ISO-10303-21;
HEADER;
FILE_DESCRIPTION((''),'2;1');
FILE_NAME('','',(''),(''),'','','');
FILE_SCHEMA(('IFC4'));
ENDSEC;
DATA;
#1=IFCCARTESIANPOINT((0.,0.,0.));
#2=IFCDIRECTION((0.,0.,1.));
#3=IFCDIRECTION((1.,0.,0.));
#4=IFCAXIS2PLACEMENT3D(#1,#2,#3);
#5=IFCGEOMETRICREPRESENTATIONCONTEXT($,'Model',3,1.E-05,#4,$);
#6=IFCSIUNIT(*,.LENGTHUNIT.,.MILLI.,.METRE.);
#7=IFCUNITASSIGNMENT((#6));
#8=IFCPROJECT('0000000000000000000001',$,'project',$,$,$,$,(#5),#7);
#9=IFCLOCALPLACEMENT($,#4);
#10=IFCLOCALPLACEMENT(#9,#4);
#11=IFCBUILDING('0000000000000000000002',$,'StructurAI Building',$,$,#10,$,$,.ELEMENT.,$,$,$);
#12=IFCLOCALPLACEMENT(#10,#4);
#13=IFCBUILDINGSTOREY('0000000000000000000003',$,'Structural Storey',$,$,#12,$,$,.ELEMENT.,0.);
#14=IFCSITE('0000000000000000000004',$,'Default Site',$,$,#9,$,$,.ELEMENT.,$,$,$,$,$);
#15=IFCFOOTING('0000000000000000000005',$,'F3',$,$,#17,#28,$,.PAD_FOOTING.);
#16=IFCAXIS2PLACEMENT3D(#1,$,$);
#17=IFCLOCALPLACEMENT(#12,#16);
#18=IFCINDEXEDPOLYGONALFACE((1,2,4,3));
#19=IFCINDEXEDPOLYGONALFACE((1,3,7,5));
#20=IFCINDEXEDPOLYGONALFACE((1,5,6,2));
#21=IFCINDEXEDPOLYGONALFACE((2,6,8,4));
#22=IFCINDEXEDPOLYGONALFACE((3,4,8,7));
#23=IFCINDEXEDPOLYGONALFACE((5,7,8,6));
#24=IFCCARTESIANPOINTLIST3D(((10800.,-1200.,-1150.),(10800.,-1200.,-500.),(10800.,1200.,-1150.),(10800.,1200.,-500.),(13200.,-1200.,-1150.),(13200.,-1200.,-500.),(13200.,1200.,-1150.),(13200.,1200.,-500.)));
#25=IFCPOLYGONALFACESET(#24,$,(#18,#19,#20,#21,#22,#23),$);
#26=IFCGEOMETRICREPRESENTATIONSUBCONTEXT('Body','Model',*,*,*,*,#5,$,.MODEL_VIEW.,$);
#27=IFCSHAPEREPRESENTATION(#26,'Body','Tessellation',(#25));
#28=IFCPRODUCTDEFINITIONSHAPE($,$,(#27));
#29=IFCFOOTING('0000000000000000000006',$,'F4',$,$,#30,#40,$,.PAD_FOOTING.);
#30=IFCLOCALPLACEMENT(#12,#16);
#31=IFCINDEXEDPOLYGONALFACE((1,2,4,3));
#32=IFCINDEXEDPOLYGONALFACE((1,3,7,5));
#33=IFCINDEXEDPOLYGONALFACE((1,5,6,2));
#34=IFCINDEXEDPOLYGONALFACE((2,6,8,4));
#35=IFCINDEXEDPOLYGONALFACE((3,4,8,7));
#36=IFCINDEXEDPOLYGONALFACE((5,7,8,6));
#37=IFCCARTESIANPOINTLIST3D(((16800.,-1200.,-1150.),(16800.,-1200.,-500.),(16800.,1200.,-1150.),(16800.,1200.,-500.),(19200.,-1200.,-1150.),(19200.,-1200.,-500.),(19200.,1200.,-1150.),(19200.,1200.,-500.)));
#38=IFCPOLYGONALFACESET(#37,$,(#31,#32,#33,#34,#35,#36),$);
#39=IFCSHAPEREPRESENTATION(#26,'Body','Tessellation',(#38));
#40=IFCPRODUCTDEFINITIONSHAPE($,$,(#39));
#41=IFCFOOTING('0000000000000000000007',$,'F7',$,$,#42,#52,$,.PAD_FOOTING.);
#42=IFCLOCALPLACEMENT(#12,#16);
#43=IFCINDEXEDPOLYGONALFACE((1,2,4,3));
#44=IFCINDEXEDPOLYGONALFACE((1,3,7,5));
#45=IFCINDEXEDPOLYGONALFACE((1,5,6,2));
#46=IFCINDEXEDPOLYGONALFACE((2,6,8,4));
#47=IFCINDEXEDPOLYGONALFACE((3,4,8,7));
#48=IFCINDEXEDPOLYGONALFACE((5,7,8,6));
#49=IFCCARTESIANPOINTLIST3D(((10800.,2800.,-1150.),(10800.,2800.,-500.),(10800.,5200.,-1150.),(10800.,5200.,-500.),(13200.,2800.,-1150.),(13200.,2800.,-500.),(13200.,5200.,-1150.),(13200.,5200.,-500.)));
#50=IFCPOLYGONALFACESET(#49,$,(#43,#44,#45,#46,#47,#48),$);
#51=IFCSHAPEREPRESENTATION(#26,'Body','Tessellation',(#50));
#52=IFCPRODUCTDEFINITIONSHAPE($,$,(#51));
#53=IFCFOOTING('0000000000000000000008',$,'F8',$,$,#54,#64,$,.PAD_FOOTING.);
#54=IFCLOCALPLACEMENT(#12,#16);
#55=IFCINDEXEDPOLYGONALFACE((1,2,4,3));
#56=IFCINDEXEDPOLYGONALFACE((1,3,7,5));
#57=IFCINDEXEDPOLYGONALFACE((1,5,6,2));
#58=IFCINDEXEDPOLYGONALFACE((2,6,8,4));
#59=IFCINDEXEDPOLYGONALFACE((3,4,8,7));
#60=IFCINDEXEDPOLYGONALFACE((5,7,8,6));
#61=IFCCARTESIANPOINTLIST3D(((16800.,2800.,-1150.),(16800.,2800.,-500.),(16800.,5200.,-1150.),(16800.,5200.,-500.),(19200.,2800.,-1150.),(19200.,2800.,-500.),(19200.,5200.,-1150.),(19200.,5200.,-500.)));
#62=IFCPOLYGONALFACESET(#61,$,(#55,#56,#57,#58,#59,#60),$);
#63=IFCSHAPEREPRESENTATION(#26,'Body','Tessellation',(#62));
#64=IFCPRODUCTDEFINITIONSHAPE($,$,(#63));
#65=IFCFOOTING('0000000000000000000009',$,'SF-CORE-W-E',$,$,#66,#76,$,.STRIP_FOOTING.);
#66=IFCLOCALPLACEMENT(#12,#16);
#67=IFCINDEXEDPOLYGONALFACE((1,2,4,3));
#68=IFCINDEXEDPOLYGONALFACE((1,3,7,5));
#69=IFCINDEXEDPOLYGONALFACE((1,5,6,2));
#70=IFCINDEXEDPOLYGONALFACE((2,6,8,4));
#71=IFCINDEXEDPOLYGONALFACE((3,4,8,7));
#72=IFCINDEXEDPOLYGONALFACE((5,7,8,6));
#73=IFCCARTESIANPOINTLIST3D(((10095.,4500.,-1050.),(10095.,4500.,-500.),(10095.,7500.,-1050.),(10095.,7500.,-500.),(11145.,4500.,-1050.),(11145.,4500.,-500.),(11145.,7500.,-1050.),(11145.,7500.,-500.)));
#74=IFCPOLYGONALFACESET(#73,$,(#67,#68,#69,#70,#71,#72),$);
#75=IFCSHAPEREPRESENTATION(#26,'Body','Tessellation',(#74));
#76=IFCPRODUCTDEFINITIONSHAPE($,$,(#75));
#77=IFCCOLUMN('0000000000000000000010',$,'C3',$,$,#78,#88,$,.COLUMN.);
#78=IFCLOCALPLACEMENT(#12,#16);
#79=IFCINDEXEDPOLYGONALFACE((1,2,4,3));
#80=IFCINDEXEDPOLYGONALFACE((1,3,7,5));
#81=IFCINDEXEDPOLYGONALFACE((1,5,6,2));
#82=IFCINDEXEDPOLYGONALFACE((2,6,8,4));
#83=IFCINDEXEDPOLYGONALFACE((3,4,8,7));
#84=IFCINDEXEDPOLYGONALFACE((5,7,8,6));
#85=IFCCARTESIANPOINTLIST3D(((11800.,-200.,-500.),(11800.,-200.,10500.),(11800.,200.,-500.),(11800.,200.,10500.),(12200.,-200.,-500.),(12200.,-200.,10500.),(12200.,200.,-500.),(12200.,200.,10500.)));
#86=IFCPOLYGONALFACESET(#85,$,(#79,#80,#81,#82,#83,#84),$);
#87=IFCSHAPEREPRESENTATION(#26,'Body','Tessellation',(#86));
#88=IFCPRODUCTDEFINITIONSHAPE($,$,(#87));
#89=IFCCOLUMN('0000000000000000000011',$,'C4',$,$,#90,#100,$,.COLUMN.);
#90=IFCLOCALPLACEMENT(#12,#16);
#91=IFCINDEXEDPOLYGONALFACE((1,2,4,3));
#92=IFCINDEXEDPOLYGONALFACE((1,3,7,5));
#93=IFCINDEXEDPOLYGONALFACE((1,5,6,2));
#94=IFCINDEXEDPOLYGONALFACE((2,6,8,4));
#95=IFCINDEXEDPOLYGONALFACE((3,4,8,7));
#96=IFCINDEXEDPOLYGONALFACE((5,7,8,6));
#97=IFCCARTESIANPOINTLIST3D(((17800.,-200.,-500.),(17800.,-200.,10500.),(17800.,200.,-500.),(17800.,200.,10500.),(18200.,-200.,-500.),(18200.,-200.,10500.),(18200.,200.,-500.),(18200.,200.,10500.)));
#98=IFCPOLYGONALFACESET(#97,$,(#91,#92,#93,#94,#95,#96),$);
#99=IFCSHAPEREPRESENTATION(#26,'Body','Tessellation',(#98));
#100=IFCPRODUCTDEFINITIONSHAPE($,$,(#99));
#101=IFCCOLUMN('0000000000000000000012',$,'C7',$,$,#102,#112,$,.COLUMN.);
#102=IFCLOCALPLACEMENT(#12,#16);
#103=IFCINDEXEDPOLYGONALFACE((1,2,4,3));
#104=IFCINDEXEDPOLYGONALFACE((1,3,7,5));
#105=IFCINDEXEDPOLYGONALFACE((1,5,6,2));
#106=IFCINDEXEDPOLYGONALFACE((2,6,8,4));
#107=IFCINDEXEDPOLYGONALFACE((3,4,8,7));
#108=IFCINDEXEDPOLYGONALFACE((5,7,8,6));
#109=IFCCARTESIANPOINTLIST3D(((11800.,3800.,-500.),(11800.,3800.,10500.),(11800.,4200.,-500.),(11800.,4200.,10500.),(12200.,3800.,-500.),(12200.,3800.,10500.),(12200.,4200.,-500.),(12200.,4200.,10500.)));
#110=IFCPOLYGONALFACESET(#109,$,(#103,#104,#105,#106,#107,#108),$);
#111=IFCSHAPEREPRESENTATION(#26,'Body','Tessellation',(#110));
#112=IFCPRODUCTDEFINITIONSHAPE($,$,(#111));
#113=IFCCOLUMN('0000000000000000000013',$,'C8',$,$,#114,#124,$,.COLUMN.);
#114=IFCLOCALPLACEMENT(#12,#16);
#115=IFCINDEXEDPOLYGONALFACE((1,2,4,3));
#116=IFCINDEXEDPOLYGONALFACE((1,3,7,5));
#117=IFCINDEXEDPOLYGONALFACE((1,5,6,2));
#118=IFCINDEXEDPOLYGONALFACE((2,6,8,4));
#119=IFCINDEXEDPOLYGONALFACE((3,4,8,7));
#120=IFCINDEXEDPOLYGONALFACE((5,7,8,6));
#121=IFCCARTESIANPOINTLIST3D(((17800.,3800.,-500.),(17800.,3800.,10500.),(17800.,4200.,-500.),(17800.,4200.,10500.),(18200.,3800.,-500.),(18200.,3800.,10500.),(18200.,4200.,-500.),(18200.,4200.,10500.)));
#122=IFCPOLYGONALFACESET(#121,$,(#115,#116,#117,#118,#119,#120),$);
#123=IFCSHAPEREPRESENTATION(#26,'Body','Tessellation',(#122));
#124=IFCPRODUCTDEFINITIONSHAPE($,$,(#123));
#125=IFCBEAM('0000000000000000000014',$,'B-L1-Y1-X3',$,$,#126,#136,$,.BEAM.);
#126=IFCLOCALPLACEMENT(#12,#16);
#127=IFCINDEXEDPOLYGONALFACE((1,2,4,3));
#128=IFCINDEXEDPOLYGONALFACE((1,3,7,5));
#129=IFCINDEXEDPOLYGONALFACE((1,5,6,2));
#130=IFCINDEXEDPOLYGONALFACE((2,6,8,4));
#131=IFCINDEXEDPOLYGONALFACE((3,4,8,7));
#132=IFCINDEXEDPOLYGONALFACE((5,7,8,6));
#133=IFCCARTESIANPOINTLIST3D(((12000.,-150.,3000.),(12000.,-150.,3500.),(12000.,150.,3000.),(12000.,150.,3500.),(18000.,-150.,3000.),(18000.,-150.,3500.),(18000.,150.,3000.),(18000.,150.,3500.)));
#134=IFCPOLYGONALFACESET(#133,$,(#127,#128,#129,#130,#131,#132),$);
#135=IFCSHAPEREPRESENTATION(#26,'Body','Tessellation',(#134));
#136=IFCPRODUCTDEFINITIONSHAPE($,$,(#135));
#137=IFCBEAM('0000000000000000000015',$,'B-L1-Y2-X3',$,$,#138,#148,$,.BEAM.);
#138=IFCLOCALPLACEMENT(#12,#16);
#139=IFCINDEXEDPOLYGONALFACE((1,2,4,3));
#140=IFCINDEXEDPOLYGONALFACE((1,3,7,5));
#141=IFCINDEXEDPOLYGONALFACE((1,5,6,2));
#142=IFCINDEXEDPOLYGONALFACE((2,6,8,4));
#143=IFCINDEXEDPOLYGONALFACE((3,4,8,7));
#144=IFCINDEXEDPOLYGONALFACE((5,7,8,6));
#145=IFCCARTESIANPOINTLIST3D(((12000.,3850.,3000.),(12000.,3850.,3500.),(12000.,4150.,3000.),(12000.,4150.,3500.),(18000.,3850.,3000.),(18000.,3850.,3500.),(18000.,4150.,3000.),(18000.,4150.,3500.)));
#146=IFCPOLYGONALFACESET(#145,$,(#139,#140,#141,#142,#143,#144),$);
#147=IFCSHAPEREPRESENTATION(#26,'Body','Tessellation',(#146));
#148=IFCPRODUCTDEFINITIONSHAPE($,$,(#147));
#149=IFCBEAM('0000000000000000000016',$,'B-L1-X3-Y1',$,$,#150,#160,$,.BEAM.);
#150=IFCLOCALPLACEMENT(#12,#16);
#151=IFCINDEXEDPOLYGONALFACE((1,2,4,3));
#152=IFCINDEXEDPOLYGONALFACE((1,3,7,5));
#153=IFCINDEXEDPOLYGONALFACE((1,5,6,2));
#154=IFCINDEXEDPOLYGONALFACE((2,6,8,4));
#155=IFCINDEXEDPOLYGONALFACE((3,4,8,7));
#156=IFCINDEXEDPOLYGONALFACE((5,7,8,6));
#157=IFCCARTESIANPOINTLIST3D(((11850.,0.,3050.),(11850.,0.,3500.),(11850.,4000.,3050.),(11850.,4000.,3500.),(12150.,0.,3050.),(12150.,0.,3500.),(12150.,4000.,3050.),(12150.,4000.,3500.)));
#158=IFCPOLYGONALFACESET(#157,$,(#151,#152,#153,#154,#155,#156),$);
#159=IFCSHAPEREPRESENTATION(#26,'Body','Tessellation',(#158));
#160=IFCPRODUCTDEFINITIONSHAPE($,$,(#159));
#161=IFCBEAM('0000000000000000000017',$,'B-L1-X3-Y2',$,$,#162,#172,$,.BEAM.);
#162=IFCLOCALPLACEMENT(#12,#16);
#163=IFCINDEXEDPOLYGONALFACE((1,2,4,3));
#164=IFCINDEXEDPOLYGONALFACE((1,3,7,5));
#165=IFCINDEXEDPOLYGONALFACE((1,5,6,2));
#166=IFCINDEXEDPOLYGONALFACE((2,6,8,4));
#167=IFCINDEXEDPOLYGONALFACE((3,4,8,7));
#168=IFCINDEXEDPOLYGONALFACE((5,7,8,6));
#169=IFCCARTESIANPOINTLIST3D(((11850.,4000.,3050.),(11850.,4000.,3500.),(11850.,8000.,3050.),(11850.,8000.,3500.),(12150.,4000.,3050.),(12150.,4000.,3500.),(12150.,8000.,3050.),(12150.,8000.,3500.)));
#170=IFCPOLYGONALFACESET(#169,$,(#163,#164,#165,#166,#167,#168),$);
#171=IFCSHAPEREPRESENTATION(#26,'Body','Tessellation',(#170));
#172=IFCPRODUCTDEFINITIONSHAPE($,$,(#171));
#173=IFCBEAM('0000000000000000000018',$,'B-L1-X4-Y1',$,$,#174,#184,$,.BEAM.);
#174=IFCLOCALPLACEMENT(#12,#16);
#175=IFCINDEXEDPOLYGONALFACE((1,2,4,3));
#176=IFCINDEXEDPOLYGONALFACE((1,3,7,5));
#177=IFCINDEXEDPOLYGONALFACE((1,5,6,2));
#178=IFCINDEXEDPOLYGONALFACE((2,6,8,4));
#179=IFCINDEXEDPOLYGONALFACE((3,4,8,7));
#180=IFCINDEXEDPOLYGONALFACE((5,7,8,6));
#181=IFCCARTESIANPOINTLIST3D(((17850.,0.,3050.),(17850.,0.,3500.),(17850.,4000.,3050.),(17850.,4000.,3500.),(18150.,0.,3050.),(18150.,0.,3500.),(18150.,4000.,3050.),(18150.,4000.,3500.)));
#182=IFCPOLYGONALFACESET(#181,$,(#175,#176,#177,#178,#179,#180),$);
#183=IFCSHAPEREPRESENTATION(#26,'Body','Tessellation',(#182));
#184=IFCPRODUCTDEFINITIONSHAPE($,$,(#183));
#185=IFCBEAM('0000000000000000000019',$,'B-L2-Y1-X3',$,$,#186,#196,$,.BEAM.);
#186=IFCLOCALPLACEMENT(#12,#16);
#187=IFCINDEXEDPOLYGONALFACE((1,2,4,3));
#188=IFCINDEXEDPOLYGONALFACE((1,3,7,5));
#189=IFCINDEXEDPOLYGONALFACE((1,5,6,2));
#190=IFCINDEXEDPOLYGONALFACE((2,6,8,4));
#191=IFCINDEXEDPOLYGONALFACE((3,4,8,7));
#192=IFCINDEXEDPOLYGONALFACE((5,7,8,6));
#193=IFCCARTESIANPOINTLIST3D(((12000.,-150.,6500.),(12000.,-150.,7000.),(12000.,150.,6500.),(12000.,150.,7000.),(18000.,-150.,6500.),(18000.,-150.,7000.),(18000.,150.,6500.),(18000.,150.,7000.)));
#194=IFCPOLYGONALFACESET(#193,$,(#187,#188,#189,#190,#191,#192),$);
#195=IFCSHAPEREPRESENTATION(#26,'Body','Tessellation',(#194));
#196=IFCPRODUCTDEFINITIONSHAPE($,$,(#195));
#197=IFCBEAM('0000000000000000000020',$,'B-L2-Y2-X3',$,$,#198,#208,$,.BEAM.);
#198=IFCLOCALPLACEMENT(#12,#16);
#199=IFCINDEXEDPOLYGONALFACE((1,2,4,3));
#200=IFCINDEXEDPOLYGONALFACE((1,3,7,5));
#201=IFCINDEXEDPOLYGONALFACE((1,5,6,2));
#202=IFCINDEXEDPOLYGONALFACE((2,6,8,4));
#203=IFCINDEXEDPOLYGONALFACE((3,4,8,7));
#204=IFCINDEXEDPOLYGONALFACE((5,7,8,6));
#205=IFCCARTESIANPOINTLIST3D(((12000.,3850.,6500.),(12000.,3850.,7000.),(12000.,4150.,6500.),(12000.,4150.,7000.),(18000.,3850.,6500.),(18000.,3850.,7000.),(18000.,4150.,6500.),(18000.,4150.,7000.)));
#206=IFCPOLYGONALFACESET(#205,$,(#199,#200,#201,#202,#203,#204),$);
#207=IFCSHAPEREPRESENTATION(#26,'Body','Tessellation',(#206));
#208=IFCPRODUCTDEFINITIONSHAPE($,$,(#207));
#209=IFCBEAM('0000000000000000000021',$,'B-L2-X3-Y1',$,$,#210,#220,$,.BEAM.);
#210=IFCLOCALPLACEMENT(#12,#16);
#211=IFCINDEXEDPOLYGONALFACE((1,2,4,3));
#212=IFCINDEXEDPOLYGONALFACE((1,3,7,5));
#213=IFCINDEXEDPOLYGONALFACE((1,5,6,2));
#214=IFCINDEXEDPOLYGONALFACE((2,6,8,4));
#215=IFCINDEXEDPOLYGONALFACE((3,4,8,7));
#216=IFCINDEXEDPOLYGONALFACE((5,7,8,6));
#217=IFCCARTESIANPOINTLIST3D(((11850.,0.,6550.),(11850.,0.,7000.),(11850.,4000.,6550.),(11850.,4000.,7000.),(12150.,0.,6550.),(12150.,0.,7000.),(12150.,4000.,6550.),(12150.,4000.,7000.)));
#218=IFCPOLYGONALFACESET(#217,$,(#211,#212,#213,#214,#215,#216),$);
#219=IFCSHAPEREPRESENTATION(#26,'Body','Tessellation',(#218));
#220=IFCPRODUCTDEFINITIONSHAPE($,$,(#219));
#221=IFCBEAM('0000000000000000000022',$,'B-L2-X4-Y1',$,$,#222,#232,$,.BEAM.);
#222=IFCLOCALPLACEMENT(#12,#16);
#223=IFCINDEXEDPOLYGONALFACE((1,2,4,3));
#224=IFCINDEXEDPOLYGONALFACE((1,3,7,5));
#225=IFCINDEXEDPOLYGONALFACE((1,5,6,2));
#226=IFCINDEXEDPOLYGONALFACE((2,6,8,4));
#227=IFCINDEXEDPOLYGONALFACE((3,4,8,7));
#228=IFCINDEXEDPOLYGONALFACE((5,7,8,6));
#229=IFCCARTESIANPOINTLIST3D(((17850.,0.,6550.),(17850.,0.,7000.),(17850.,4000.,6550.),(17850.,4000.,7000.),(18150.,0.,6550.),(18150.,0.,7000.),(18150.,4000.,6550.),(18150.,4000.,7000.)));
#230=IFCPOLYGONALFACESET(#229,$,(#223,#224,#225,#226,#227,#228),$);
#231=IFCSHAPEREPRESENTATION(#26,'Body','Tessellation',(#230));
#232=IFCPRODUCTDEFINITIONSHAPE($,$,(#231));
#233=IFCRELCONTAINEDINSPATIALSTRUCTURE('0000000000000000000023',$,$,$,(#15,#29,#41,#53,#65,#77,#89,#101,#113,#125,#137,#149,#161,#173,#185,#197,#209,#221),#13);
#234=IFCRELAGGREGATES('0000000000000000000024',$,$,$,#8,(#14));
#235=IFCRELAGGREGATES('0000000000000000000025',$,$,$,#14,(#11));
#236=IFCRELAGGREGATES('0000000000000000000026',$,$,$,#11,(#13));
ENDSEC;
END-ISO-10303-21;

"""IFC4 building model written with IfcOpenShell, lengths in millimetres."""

from ifc_helpers import new_model, si_unit, frame, origin_with_axes, place, context, subcontext, project, spatial, rectangle, extrude, element, save


model = new_model("IFC4")

# Units and contexts
model_context = context("Model", 3, precision=1e-05, world=origin_with_axes())
body_context = subcontext(model_context, "Body", "Model", "MODEL_VIEW")
ifc_project = project(units=[si_unit("LENGTHUNIT", "METRE", prefix="MILLI")], contexts=[model_context])

# Site, building, storey
site_placement = place(None, origin_with_axes())
site = spatial("IfcSite", under=ifc_project, at=site_placement, Name="Default Site", CompositionType="ELEMENT")
building_placement = place(site_placement, origin_with_axes())
building = spatial("IfcBuilding", under=site, at=building_placement, Name="StructurAI Building", CompositionType="ELEMENT")
storey_placement = place(building_placement, origin_with_axes())
storey = spatial("IfcBuildingStorey", under=building, at=storey_placement, Name="Structural Storey", CompositionType="ELEMENT", Elevation=0.0)

# Footings
for number, where, z_axis, x_axis, name in (
    (1, (12000.0, 0.0, -1150.0), (0.0, 0.0, 1.0), (1.0, 0.0, 0.0), "F3"),
    (2, (18000.0, 0.0, -1150.0), (0.0, 0.0, 1.0), (1.0, 0.0, 0.0), "F4"),
    (3, (12000.0, 4000.0, -1150.0), (0.0, 0.0, 1.0), (1.0, 0.0, 0.0), "F7"),
    (4, (18000.0, 4000.0, -1150.0), (0.0, 0.0, 1.0), (1.0, 0.0, 0.0), "F8"),
):
    element("IfcFooting", number, at=place(storey_placement, frame(where, z_axis=z_axis, x_axis=x_axis)), inside=storey, Name=name, PredefinedType="PAD_FOOTING", context=body_context, shape_type="SweptSolid", body=[
        extrude(rectangle(XDim=2400.0, YDim=2400.0), origin_with_axes(), (0.0, 0.0, 1.0), 650.0),
    ])
footing_placement = place(storey_placement, frame((10620.0, 6000.0, -1050.0), z_axis=(0.0, 0.0, 1.0), x_axis=(0.0, 1.0, 0.0)))
element("IfcFooting", 5, at=footing_placement, inside=storey, Name="SF-CORE-W-E", PredefinedType="STRIP_FOOTING", context=body_context, shape_type="SweptSolid", body=[
    extrude(rectangle(XDim=3000.0, YDim=1050.0), origin_with_axes(), (0.0, 0.0, 1.0), 550.0),
])

# Columns
for number, where, z_axis, x_axis, name in (
    (6, (12000.0, 0.0, -500.0), (0.0, 0.0, 1.0), (1.0, 0.0, 0.0), "C3"),
    (7, (18000.0, 0.0, -500.0), (0.0, 0.0, 1.0), (1.0, 0.0, 0.0), "C4"),
    (8, (12000.0, 4000.0, -500.0), (0.0, 0.0, 1.0), (1.0, 0.0, 0.0), "C7"),
    (9, (18000.0, 4000.0, -500.0), (0.0, 0.0, 1.0), (1.0, 0.0, 0.0), "C8"),
):
    element("IfcColumn", number, at=place(storey_placement, frame(where, z_axis=z_axis, x_axis=x_axis)), inside=storey, Name=name, PredefinedType="COLUMN", context=body_context, shape_type="SweptSolid", body=[
        extrude(rectangle(XDim=400.0, YDim=400.0), origin_with_axes(), (0.0, 0.0, 1.0), 11000.0),
    ])

# Beams
for number, where, z_axis, x_axis, name in (
    (10, (15000.0, 0.0, 3000.0), (0.0, 0.0, 1.0), (1.0, 0.0, 0.0), "B-L1-Y1-X3"),
    (11, (15000.0, 4000.0, 3000.0), (0.0, 0.0, 1.0), (1.0, 0.0, 0.0), "B-L1-Y2-X3"),
):
    element("IfcBeam", number, at=place(storey_placement, frame(where, z_axis=z_axis, x_axis=x_axis)), inside=storey, Name=name, PredefinedType="BEAM", context=body_context, shape_type="SweptSolid", body=[
        extrude(rectangle(XDim=6000.0, YDim=300.0), origin_with_axes(), (0.0, 0.0, 1.0), 500.0),
    ])
for number, where, z_axis, x_axis, name in (
    (12, (12000.0, 2000.0, 3050.0), (0.0, 0.0, 1.0), (0.0, 1.0, 0.0), "B-L1-X3-Y1"),
    (13, (12000.0, 6000.0, 3050.0), (0.0, 0.0, 1.0), (0.0, 1.0, 0.0), "B-L1-X3-Y2"),
    (14, (18000.0, 2000.0, 3050.0), (0.0, 0.0, 1.0), (0.0, 1.0, 0.0), "B-L1-X4-Y1"),
):
    element("IfcBeam", number, at=place(storey_placement, frame(where, z_axis=z_axis, x_axis=x_axis)), inside=storey, Name=name, PredefinedType="BEAM", context=body_context, shape_type="SweptSolid", body=[
        extrude(rectangle(XDim=4000.0, YDim=300.0), origin_with_axes(), (0.0, 0.0, 1.0), 450.0),
    ])
for number, where, z_axis, x_axis, name in (
    (15, (15000.0, 0.0, 6500.0), (0.0, 0.0, 1.0), (1.0, 0.0, 0.0), "B-L2-Y1-X3"),
    (16, (15000.0, 4000.0, 6500.0), (0.0, 0.0, 1.0), (1.0, 0.0, 0.0), "B-L2-Y2-X3"),
):
    element("IfcBeam", number, at=place(storey_placement, frame(where, z_axis=z_axis, x_axis=x_axis)), inside=storey, Name=name, PredefinedType="BEAM", context=body_context, shape_type="SweptSolid", body=[
        extrude(rectangle(XDim=6000.0, YDim=300.0), origin_with_axes(), (0.0, 0.0, 1.0), 500.0),
    ])
for number, where, z_axis, x_axis, name in (
    (17, (12000.0, 2000.0, 6550.0), (0.0, 0.0, 1.0), (0.0, 1.0, 0.0), "B-L2-X3-Y1"),
    (18, (18000.0, 2000.0, 6550.0), (0.0, 0.0, 1.0), (0.0, 1.0, 0.0), "B-L2-X4-Y1"),
):
    element("IfcBeam", number, at=place(storey_placement, frame(where, z_axis=z_axis, x_axis=x_axis)), inside=storey, Name=name, PredefinedType="BEAM", context=body_context, shape_type="SweptSolid", body=[
        extrude(rectangle(XDim=4000.0, YDim=300.0), origin_with_axes(), (0.0, 0.0, 1.0), 450.0),
    ])

save(model, "model.ifc")
